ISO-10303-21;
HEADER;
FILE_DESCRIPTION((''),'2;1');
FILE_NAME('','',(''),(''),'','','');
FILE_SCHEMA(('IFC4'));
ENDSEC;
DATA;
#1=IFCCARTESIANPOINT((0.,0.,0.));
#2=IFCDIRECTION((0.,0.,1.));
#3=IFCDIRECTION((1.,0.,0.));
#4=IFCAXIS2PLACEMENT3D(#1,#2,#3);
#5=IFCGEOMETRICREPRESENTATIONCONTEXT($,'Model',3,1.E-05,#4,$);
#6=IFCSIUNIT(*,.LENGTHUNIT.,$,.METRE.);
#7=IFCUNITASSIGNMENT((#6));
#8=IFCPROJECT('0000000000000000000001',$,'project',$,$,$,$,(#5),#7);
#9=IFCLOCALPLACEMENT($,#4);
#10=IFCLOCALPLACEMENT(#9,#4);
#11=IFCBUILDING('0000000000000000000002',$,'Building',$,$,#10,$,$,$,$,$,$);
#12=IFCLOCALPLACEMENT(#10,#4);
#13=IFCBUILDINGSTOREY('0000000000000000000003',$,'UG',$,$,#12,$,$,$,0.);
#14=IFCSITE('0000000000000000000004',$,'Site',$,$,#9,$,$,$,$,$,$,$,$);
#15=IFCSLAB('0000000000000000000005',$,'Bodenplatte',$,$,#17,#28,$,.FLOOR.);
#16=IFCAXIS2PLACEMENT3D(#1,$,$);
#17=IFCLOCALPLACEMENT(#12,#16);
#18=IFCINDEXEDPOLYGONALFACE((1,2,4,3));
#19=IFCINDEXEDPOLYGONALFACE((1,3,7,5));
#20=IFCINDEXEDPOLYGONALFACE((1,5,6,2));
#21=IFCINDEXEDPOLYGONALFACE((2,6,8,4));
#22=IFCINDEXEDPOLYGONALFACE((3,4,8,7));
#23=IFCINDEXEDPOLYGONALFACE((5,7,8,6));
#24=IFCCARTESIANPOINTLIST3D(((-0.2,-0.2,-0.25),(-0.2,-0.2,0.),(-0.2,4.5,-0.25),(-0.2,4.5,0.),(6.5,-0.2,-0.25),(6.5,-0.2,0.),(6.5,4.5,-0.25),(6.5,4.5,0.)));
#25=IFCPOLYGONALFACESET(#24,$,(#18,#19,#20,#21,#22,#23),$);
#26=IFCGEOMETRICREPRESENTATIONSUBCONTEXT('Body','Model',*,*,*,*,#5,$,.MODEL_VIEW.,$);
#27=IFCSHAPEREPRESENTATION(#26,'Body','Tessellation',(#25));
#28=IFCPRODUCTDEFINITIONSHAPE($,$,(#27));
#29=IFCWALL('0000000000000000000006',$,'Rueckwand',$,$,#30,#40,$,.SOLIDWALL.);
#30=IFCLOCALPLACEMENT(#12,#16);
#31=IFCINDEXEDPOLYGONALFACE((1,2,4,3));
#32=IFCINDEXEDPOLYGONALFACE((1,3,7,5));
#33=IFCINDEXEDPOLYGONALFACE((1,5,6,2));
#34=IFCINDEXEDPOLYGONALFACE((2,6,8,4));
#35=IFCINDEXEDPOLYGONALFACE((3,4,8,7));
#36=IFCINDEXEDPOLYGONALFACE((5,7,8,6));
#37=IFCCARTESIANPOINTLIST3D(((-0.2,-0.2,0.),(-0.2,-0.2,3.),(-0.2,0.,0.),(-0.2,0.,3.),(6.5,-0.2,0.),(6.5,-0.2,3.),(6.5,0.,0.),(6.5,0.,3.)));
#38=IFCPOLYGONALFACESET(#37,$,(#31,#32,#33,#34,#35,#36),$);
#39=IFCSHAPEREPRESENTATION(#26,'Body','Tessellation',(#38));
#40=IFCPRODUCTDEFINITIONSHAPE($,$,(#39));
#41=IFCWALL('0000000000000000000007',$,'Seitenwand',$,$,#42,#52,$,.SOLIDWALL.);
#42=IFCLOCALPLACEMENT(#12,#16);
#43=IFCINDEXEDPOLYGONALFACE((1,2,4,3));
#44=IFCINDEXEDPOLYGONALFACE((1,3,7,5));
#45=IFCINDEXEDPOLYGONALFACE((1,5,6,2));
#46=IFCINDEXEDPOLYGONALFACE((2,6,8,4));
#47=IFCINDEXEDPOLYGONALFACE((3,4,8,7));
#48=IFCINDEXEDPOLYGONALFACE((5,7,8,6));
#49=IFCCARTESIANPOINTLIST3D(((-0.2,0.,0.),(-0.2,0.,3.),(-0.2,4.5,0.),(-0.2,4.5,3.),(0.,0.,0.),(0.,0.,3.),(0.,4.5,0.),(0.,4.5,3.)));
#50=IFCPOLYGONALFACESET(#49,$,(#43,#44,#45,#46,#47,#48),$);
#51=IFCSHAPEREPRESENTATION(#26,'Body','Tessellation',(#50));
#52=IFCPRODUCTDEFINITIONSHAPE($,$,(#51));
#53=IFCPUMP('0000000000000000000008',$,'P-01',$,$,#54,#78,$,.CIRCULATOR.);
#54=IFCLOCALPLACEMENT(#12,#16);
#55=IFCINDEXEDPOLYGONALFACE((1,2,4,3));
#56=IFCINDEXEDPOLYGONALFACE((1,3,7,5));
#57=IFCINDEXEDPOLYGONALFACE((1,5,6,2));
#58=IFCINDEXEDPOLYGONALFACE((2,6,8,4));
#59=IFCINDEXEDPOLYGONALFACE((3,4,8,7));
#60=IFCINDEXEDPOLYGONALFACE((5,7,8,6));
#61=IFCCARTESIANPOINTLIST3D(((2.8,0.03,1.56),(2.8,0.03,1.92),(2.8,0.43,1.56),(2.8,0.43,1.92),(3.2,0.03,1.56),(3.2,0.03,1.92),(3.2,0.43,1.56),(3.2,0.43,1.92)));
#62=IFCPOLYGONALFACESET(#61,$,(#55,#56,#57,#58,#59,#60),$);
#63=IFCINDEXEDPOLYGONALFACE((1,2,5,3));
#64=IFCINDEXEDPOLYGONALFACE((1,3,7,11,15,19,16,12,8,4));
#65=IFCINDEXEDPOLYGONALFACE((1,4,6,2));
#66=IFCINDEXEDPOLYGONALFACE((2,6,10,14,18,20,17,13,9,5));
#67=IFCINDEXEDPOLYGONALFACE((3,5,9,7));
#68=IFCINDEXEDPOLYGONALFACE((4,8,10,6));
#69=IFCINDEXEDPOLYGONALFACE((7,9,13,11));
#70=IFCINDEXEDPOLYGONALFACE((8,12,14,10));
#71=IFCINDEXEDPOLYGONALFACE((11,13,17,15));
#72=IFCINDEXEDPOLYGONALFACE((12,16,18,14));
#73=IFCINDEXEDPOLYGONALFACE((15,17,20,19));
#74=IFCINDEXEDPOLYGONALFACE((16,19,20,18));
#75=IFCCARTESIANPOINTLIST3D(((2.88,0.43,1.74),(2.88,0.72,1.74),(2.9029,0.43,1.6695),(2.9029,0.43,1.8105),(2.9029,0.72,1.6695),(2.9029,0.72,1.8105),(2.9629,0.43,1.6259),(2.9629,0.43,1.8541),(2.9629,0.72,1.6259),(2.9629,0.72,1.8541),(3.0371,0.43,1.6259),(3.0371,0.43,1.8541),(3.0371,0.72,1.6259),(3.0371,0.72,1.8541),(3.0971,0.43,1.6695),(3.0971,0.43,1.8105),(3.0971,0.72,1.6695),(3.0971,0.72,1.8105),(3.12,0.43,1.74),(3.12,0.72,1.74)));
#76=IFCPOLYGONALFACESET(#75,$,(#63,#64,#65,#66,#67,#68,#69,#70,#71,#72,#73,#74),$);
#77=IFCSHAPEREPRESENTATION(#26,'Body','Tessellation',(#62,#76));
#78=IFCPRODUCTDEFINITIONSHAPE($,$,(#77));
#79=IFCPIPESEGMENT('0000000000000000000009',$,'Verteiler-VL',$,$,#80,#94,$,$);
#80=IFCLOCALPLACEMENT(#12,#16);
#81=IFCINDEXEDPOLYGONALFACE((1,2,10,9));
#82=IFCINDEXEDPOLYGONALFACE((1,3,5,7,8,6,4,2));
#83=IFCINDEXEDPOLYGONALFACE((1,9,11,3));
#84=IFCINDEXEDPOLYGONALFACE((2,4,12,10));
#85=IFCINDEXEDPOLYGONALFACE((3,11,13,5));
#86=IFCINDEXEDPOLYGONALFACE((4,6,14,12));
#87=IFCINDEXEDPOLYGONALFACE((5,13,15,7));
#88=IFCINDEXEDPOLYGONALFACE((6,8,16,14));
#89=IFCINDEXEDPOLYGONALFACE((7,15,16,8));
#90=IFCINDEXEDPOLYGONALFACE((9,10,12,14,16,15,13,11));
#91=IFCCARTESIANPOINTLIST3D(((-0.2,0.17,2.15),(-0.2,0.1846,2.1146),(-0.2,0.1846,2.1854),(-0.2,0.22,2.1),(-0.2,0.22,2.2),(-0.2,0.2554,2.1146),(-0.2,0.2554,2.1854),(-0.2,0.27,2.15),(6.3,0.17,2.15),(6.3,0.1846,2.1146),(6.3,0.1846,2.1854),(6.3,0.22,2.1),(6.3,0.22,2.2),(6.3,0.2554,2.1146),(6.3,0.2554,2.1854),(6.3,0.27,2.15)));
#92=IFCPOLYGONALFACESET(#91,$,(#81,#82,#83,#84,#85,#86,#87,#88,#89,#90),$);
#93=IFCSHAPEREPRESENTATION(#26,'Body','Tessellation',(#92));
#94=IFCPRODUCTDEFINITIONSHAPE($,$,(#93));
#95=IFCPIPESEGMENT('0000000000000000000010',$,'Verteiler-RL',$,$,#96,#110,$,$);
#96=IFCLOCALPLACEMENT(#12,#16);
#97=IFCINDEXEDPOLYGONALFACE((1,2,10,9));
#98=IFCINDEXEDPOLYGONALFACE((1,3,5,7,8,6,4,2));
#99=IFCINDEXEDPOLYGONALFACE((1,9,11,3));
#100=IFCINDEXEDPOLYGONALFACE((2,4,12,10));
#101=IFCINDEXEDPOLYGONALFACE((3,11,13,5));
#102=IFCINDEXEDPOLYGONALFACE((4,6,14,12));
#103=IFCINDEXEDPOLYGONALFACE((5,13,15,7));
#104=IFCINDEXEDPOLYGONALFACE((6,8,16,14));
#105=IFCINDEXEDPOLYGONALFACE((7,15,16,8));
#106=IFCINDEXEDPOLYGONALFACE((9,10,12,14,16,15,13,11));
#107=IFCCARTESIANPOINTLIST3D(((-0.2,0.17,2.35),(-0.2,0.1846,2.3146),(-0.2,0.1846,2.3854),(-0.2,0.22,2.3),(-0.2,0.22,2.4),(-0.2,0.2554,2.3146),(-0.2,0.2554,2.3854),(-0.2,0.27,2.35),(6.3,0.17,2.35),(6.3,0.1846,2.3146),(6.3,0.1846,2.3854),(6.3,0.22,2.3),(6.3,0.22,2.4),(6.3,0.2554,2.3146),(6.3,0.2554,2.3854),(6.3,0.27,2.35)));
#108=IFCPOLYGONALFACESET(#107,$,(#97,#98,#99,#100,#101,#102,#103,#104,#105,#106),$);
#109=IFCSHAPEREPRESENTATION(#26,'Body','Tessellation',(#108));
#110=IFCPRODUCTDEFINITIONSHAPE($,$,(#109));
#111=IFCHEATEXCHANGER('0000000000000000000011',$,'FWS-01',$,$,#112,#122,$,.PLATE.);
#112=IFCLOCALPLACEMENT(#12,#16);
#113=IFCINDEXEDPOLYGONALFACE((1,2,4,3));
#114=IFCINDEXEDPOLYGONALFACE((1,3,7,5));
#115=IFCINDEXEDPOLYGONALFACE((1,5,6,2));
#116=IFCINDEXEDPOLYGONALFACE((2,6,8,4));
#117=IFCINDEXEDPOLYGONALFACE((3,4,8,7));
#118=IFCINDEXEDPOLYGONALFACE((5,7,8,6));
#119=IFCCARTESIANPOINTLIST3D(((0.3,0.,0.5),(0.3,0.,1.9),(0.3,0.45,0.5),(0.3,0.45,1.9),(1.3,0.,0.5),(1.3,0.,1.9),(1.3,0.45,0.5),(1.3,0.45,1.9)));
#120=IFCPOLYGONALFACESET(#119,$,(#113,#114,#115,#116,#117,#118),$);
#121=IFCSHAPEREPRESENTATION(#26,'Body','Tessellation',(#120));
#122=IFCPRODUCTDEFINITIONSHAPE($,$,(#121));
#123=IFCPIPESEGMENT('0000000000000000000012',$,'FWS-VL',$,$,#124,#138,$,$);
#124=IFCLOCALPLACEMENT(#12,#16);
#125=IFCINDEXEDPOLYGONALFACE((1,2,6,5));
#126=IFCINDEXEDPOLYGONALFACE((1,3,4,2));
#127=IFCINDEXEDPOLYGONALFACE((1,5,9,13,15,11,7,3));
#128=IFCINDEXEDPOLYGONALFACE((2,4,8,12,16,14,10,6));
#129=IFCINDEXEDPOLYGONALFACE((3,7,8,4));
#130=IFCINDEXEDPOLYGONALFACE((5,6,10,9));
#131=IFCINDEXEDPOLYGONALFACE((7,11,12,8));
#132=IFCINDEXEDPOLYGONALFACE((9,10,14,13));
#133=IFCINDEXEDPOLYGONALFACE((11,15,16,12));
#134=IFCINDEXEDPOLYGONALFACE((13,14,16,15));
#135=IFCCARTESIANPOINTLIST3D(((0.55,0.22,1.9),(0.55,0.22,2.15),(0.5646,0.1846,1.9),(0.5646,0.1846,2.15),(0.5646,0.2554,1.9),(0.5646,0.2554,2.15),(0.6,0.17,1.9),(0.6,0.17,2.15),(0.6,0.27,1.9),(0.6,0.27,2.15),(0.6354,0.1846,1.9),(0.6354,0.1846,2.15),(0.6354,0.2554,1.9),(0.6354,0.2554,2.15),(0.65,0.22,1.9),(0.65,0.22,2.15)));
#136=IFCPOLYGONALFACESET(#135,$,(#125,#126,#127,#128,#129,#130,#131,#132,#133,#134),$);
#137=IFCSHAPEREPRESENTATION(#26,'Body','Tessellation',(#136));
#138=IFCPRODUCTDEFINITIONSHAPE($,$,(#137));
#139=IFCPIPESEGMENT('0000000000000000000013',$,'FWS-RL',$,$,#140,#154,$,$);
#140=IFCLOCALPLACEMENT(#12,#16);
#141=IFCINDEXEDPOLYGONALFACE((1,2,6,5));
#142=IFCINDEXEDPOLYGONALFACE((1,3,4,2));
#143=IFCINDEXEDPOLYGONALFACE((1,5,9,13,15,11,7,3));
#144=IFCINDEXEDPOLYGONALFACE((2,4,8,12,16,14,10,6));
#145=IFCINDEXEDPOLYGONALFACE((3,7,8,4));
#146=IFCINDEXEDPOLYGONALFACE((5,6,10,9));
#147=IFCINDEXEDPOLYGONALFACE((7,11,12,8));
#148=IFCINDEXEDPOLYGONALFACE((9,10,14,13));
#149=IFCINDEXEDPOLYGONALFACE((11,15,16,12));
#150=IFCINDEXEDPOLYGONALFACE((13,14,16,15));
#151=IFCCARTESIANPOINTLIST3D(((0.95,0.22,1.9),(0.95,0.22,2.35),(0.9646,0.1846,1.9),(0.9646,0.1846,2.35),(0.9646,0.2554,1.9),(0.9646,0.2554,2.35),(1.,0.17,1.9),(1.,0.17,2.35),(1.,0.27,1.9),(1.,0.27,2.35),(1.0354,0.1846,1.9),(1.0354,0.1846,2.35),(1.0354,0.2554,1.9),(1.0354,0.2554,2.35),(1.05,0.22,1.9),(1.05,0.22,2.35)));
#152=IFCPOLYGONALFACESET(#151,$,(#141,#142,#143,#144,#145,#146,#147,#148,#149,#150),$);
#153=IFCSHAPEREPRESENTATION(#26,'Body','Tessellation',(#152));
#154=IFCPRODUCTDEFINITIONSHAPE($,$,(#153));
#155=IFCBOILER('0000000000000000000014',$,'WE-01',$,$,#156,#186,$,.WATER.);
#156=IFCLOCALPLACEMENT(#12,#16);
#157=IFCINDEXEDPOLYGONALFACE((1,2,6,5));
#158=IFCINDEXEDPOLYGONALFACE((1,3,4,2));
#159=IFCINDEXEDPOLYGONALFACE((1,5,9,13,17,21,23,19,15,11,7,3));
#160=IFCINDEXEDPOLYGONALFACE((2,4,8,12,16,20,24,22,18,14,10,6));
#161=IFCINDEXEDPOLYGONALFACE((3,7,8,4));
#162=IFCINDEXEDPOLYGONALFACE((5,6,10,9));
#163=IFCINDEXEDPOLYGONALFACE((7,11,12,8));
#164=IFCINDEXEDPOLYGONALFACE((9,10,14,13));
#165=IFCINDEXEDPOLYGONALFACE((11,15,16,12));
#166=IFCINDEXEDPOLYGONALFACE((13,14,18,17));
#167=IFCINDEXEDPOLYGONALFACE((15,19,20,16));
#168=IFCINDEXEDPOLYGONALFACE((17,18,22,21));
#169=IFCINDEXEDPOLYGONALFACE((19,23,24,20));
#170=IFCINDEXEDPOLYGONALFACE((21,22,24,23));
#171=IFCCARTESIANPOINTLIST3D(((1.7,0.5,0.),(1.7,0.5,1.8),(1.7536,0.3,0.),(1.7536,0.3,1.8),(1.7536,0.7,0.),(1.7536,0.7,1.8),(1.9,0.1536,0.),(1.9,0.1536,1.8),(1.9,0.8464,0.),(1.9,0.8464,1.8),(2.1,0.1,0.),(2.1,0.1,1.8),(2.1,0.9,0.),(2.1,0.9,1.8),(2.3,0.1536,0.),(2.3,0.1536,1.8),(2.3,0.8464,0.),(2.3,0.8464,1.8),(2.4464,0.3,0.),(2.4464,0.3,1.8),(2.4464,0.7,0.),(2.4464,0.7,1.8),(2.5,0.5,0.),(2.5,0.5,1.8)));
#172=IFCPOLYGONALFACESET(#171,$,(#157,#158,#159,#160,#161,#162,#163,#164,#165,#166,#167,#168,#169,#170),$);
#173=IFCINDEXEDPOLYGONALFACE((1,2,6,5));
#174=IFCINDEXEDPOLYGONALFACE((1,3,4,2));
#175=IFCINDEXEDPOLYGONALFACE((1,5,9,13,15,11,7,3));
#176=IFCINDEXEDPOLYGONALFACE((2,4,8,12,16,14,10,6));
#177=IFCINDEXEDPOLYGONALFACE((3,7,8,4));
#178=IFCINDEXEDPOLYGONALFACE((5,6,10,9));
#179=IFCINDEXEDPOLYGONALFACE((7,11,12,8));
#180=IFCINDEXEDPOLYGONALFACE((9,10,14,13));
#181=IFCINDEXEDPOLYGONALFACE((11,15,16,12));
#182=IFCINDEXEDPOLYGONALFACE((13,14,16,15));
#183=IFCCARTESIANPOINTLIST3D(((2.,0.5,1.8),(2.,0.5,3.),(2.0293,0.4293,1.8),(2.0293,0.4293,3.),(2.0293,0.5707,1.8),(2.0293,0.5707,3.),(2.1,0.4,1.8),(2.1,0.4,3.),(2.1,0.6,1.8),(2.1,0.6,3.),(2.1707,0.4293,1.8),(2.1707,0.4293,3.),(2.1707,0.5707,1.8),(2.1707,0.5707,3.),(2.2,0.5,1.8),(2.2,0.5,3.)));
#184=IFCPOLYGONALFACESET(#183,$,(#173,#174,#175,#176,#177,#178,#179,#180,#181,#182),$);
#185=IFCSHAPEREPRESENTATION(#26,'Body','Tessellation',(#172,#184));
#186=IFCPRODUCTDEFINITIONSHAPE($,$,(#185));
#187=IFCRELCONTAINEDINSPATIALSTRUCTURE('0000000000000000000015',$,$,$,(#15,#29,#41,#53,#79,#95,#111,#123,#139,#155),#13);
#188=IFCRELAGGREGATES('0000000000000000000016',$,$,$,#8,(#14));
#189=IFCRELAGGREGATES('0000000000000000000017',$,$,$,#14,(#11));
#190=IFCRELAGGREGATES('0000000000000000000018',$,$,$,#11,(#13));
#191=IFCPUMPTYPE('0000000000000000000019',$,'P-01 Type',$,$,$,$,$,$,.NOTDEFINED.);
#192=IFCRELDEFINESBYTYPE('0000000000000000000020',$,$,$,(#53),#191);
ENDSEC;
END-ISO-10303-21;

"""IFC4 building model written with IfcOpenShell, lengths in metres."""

from ifc_helpers import new_model, si_unit, frame, origin_with_axes, place, context, subcontext, project, spatial, polyline, outline, extrude, type_object, element, save


model = new_model("IFC4")

# Units and contexts
model_context = context("Model", 3, precision=1e-05, world=origin_with_axes())
body_context = subcontext(model_context, "Body", "Model", "MODEL_VIEW")
ifc_project = project(units=[si_unit("LENGTHUNIT", "METRE")], contexts=[model_context])

# Site, building, storey
site_placement = place(None, origin_with_axes())
site = spatial("IfcSite", under=ifc_project, at=site_placement, Name="Site")
building_placement = place(site_placement, origin_with_axes())
building = spatial("IfcBuilding", under=site, at=building_placement, Name="Building")
storey_placement = place(building_placement, origin_with_axes())
storey = spatial("IfcBuildingStorey", under=building, at=storey_placement, Name="UG", Elevation=0.0)

# Slab
slab_placement = place(storey_placement, frame((0.0, 0.0, -0.25), z_axis=(0.0, 0.0, 1.0), x_axis=(1.0, 0.0, 0.0)))
element("IfcSlab", 1, at=slab_placement, inside=storey, Name="Bodenplatte", PredefinedType="FLOOR", context=body_context, shape_type="SweptSolid", body=[
    extrude(outline(polyline([(-0.2, -0.2, 0.0), (6.5, -0.2, 0.0), (6.5, 4.5, 0.0), (-0.2, 4.5, 0.0), (-0.2, -0.2, 0.0)])), origin_with_axes(), (0.0, 0.0, 1.0), 0.25),
])

# Walls
wall_1_placement = place(storey_placement, frame((-0.2, -0.2, 0.0), z_axis=(0.0, 0.0, 1.0), x_axis=(1.0, 0.0, 0.0)))
element("IfcWall", 2, at=wall_1_placement, inside=storey, Name="Rueckwand", PredefinedType="SOLIDWALL", context=body_context, shape_type="SweptSolid", body=[
    extrude(outline(polyline([(0.0, 0.0, 0.0), (6.7, 0.0, 0.0), (6.7, 0.2, 0.0), (0.0, 0.2, 0.0), (0.0, 0.0, 0.0)])), origin_with_axes(), (0.0, 0.0, 1.0), 3.0),
])
wall_2_placement = place(storey_placement, frame((0.0, 0.0, 0.0), z_axis=(0.0, 0.0, 1.0), x_axis=(0.0, 1.0, 0.0)))
element("IfcWall", 3, at=wall_2_placement, inside=storey, Name="Seitenwand", PredefinedType="SOLIDWALL", context=body_context, shape_type="SweptSolid", body=[
    extrude(outline(polyline([(0.0, 0.0, 0.0), (4.5, 0.0, 0.0), (4.5, 0.2, 0.0), (0.0, 0.2, 0.0), (0.0, 0.0, 0.0)])), origin_with_axes(), (0.0, 0.0, 1.0), 3.0),
])

# Pump
pump_type = type_object("IfcPumpType", Name="P-01 Type", PredefinedType="NOTDEFINED")
pump_placement = place(storey_placement, origin_with_axes())
element("IfcPump", 4, at=pump_placement, inside=storey, type_object=pump_type, Name="P-01", PredefinedType="CIRCULATOR", context=body_context, shape_type="SweptSolid", body=[
    extrude(outline(polyline([(2.8, 0.03, 0.0), (3.2, 0.03, 0.0), (3.2, 0.43, 0.0), (2.8, 0.43, 0.0), (2.8, 0.03, 0.0)])), frame((0.0, 0.0, 1.56), z_axis=(0.0, 0.0, 1.0), x_axis=(1.0, 0.0, 0.0)), (0.0, 0.0, 1.0), 0.36),
    extrude(outline(polyline([(0.12, 0.0, 0.0), (0.0971, 0.0705, 0.0), (0.0371, 0.1141, 0.0), (-0.0371, 0.1141, 0.0), (-0.0971, 0.0705, 0.0), (-0.12, 0.0, 0.0), (-0.0971, -0.0705, 0.0), (-0.0371, -0.1141, 0.0), (0.0371, -0.1141, 0.0), (0.0971, -0.0705, 0.0), (0.12, 0.0, 0.0)])), frame((3.0, 0.43, 1.74), z_axis=(0.0, 1.0, 0.0), x_axis=(-1.0, 0.0, 0.0)), (0.0, 0.0, 1.0), 0.29),
])

# Pipe segments
pipe_segment_1_placement = place(storey_placement, origin_with_axes())
element("IfcPipeSegment", 5, at=pipe_segment_1_placement, inside=storey, Name="Verteiler-VL", context=body_context, shape_type="SweptSolid", body=[
    extrude(outline(polyline([(0.05, 0.0, 0.0), (0.0354, 0.0354, 0.0), (0.0, 0.05, 0.0), (-0.0354, 0.0354, 0.0), (-0.05, 0.0, 0.0), (-0.0354, -0.0354, 0.0), (0.0, -0.05, 0.0), (0.0354, -0.0354, 0.0), (0.05, 0.0, 0.0)])), frame((-0.2, 0.22, 2.15), z_axis=(1.0, 0.0, 0.0), x_axis=(0.0, 1.0, 0.0)), (0.0, 0.0, 1.0), 6.5),
])
pipe_segment_2_placement = place(storey_placement, origin_with_axes())
element("IfcPipeSegment", 6, at=pipe_segment_2_placement, inside=storey, Name="Verteiler-RL", context=body_context, shape_type="SweptSolid", body=[
    extrude(outline(polyline([(0.05, 0.0, 0.0), (0.0354, 0.0354, 0.0), (0.0, 0.05, 0.0), (-0.0354, 0.0354, 0.0), (-0.05, 0.0, 0.0), (-0.0354, -0.0354, 0.0), (0.0, -0.05, 0.0), (0.0354, -0.0354, 0.0), (0.05, 0.0, 0.0)])), frame((-0.2, 0.22, 2.35), z_axis=(1.0, 0.0, 0.0), x_axis=(0.0, 1.0, 0.0)), (0.0, 0.0, 1.0), 6.5),
])

# Heat exchanger
heat_exchanger_placement = place(storey_placement, origin_with_axes())
element("IfcHeatExchanger", 7, at=heat_exchanger_placement, inside=storey, Name="FWS-01", PredefinedType="PLATE", context=body_context, shape_type="SweptSolid", body=[
    extrude(outline(polyline([(0.3, 0.0, 0.0), (1.3, 0.0, 0.0), (1.3, 0.45, 0.0), (0.3, 0.45, 0.0), (0.3, 0.0, 0.0)])), frame((0.0, 0.0, 0.5), z_axis=(0.0, 0.0, 1.0), x_axis=(1.0, 0.0, 0.0)), (0.0, 0.0, 1.0), 1.4),
])

# Pipe segments
pipe_segment_3_placement = place(storey_placement, origin_with_axes())
element("IfcPipeSegment", 8, at=pipe_segment_3_placement, inside=storey, Name="FWS-VL", context=body_context, shape_type="SweptSolid", body=[
    extrude(outline(polyline([(0.05, 0.0, 0.0), (0.0354, 0.0354, 0.0), (0.0, 0.05, 0.0), (-0.0354, 0.0354, 0.0), (-0.05, 0.0, 0.0), (-0.0354, -0.0354, 0.0), (0.0, -0.05, 0.0), (0.0354, -0.0354, 0.0), (0.05, 0.0, 0.0)])), frame((0.6, 0.22, 1.9), z_axis=(0.0, 0.0, 1.0), x_axis=(1.0, 0.0, 0.0)), (0.0, 0.0, 1.0), 0.25),
])
pipe_segment_4_placement = place(storey_placement, origin_with_axes())
element("IfcPipeSegment", 9, at=pipe_segment_4_placement, inside=storey, Name="FWS-RL", context=body_context, shape_type="SweptSolid", body=[
    extrude(outline(polyline([(0.05, 0.0, 0.0), (0.0354, 0.0354, 0.0), (0.0, 0.05, 0.0), (-0.0354, 0.0354, 0.0), (-0.05, 0.0, 0.0), (-0.0354, -0.0354, 0.0), (0.0, -0.05, 0.0), (0.0354, -0.0354, 0.0), (0.05, 0.0, 0.0)])), frame((1.0, 0.22, 1.9), z_axis=(0.0, 0.0, 1.0), x_axis=(1.0, 0.0, 0.0)), (0.0, 0.0, 1.0), 0.45),
])

# Boiler
boiler_placement = place(storey_placement, origin_with_axes())
element("IfcBoiler", 10, at=boiler_placement, inside=storey, Name="WE-01", PredefinedType="WATER", context=body_context, shape_type="SweptSolid", body=[
    extrude(outline(polyline([(0.4, 0.0, 0.0), (0.3464, 0.2, 0.0), (0.2, 0.3464, 0.0), (0.0, 0.4, 0.0), (-0.2, 0.3464, 0.0), (-0.3464, 0.2, 0.0), (-0.4, 0.0, 0.0), (-0.3464, -0.2, 0.0), (-0.2, -0.3464, 0.0), (0.0, -0.4, 0.0), (0.2, -0.3464, 0.0), (0.3464, -0.2, 0.0), (0.4, 0.0, 0.0)])), frame((2.1, 0.5, 0.0), z_axis=(0.0, 0.0, 1.0), x_axis=(1.0, 0.0, 0.0)), (0.0, 0.0, 1.0), 1.8),
    extrude(outline(polyline([(0.1, 0.0, 0.0), (0.0707, 0.0707, 0.0), (0.0, 0.1, 0.0), (-0.0707, 0.0707, 0.0), (-0.1, 0.0, 0.0), (-0.0707, -0.0707, 0.0), (0.0, -0.1, 0.0), (0.0707, -0.0707, 0.0), (0.1, 0.0, 0.0)])), frame((2.1, 0.5, 1.8), z_axis=(0.0, 0.0, 1.0), x_axis=(1.0, 0.0, 0.0)), (0.0, 0.0, 1.0), 1.2),
])

save(model, "model.ifc")
